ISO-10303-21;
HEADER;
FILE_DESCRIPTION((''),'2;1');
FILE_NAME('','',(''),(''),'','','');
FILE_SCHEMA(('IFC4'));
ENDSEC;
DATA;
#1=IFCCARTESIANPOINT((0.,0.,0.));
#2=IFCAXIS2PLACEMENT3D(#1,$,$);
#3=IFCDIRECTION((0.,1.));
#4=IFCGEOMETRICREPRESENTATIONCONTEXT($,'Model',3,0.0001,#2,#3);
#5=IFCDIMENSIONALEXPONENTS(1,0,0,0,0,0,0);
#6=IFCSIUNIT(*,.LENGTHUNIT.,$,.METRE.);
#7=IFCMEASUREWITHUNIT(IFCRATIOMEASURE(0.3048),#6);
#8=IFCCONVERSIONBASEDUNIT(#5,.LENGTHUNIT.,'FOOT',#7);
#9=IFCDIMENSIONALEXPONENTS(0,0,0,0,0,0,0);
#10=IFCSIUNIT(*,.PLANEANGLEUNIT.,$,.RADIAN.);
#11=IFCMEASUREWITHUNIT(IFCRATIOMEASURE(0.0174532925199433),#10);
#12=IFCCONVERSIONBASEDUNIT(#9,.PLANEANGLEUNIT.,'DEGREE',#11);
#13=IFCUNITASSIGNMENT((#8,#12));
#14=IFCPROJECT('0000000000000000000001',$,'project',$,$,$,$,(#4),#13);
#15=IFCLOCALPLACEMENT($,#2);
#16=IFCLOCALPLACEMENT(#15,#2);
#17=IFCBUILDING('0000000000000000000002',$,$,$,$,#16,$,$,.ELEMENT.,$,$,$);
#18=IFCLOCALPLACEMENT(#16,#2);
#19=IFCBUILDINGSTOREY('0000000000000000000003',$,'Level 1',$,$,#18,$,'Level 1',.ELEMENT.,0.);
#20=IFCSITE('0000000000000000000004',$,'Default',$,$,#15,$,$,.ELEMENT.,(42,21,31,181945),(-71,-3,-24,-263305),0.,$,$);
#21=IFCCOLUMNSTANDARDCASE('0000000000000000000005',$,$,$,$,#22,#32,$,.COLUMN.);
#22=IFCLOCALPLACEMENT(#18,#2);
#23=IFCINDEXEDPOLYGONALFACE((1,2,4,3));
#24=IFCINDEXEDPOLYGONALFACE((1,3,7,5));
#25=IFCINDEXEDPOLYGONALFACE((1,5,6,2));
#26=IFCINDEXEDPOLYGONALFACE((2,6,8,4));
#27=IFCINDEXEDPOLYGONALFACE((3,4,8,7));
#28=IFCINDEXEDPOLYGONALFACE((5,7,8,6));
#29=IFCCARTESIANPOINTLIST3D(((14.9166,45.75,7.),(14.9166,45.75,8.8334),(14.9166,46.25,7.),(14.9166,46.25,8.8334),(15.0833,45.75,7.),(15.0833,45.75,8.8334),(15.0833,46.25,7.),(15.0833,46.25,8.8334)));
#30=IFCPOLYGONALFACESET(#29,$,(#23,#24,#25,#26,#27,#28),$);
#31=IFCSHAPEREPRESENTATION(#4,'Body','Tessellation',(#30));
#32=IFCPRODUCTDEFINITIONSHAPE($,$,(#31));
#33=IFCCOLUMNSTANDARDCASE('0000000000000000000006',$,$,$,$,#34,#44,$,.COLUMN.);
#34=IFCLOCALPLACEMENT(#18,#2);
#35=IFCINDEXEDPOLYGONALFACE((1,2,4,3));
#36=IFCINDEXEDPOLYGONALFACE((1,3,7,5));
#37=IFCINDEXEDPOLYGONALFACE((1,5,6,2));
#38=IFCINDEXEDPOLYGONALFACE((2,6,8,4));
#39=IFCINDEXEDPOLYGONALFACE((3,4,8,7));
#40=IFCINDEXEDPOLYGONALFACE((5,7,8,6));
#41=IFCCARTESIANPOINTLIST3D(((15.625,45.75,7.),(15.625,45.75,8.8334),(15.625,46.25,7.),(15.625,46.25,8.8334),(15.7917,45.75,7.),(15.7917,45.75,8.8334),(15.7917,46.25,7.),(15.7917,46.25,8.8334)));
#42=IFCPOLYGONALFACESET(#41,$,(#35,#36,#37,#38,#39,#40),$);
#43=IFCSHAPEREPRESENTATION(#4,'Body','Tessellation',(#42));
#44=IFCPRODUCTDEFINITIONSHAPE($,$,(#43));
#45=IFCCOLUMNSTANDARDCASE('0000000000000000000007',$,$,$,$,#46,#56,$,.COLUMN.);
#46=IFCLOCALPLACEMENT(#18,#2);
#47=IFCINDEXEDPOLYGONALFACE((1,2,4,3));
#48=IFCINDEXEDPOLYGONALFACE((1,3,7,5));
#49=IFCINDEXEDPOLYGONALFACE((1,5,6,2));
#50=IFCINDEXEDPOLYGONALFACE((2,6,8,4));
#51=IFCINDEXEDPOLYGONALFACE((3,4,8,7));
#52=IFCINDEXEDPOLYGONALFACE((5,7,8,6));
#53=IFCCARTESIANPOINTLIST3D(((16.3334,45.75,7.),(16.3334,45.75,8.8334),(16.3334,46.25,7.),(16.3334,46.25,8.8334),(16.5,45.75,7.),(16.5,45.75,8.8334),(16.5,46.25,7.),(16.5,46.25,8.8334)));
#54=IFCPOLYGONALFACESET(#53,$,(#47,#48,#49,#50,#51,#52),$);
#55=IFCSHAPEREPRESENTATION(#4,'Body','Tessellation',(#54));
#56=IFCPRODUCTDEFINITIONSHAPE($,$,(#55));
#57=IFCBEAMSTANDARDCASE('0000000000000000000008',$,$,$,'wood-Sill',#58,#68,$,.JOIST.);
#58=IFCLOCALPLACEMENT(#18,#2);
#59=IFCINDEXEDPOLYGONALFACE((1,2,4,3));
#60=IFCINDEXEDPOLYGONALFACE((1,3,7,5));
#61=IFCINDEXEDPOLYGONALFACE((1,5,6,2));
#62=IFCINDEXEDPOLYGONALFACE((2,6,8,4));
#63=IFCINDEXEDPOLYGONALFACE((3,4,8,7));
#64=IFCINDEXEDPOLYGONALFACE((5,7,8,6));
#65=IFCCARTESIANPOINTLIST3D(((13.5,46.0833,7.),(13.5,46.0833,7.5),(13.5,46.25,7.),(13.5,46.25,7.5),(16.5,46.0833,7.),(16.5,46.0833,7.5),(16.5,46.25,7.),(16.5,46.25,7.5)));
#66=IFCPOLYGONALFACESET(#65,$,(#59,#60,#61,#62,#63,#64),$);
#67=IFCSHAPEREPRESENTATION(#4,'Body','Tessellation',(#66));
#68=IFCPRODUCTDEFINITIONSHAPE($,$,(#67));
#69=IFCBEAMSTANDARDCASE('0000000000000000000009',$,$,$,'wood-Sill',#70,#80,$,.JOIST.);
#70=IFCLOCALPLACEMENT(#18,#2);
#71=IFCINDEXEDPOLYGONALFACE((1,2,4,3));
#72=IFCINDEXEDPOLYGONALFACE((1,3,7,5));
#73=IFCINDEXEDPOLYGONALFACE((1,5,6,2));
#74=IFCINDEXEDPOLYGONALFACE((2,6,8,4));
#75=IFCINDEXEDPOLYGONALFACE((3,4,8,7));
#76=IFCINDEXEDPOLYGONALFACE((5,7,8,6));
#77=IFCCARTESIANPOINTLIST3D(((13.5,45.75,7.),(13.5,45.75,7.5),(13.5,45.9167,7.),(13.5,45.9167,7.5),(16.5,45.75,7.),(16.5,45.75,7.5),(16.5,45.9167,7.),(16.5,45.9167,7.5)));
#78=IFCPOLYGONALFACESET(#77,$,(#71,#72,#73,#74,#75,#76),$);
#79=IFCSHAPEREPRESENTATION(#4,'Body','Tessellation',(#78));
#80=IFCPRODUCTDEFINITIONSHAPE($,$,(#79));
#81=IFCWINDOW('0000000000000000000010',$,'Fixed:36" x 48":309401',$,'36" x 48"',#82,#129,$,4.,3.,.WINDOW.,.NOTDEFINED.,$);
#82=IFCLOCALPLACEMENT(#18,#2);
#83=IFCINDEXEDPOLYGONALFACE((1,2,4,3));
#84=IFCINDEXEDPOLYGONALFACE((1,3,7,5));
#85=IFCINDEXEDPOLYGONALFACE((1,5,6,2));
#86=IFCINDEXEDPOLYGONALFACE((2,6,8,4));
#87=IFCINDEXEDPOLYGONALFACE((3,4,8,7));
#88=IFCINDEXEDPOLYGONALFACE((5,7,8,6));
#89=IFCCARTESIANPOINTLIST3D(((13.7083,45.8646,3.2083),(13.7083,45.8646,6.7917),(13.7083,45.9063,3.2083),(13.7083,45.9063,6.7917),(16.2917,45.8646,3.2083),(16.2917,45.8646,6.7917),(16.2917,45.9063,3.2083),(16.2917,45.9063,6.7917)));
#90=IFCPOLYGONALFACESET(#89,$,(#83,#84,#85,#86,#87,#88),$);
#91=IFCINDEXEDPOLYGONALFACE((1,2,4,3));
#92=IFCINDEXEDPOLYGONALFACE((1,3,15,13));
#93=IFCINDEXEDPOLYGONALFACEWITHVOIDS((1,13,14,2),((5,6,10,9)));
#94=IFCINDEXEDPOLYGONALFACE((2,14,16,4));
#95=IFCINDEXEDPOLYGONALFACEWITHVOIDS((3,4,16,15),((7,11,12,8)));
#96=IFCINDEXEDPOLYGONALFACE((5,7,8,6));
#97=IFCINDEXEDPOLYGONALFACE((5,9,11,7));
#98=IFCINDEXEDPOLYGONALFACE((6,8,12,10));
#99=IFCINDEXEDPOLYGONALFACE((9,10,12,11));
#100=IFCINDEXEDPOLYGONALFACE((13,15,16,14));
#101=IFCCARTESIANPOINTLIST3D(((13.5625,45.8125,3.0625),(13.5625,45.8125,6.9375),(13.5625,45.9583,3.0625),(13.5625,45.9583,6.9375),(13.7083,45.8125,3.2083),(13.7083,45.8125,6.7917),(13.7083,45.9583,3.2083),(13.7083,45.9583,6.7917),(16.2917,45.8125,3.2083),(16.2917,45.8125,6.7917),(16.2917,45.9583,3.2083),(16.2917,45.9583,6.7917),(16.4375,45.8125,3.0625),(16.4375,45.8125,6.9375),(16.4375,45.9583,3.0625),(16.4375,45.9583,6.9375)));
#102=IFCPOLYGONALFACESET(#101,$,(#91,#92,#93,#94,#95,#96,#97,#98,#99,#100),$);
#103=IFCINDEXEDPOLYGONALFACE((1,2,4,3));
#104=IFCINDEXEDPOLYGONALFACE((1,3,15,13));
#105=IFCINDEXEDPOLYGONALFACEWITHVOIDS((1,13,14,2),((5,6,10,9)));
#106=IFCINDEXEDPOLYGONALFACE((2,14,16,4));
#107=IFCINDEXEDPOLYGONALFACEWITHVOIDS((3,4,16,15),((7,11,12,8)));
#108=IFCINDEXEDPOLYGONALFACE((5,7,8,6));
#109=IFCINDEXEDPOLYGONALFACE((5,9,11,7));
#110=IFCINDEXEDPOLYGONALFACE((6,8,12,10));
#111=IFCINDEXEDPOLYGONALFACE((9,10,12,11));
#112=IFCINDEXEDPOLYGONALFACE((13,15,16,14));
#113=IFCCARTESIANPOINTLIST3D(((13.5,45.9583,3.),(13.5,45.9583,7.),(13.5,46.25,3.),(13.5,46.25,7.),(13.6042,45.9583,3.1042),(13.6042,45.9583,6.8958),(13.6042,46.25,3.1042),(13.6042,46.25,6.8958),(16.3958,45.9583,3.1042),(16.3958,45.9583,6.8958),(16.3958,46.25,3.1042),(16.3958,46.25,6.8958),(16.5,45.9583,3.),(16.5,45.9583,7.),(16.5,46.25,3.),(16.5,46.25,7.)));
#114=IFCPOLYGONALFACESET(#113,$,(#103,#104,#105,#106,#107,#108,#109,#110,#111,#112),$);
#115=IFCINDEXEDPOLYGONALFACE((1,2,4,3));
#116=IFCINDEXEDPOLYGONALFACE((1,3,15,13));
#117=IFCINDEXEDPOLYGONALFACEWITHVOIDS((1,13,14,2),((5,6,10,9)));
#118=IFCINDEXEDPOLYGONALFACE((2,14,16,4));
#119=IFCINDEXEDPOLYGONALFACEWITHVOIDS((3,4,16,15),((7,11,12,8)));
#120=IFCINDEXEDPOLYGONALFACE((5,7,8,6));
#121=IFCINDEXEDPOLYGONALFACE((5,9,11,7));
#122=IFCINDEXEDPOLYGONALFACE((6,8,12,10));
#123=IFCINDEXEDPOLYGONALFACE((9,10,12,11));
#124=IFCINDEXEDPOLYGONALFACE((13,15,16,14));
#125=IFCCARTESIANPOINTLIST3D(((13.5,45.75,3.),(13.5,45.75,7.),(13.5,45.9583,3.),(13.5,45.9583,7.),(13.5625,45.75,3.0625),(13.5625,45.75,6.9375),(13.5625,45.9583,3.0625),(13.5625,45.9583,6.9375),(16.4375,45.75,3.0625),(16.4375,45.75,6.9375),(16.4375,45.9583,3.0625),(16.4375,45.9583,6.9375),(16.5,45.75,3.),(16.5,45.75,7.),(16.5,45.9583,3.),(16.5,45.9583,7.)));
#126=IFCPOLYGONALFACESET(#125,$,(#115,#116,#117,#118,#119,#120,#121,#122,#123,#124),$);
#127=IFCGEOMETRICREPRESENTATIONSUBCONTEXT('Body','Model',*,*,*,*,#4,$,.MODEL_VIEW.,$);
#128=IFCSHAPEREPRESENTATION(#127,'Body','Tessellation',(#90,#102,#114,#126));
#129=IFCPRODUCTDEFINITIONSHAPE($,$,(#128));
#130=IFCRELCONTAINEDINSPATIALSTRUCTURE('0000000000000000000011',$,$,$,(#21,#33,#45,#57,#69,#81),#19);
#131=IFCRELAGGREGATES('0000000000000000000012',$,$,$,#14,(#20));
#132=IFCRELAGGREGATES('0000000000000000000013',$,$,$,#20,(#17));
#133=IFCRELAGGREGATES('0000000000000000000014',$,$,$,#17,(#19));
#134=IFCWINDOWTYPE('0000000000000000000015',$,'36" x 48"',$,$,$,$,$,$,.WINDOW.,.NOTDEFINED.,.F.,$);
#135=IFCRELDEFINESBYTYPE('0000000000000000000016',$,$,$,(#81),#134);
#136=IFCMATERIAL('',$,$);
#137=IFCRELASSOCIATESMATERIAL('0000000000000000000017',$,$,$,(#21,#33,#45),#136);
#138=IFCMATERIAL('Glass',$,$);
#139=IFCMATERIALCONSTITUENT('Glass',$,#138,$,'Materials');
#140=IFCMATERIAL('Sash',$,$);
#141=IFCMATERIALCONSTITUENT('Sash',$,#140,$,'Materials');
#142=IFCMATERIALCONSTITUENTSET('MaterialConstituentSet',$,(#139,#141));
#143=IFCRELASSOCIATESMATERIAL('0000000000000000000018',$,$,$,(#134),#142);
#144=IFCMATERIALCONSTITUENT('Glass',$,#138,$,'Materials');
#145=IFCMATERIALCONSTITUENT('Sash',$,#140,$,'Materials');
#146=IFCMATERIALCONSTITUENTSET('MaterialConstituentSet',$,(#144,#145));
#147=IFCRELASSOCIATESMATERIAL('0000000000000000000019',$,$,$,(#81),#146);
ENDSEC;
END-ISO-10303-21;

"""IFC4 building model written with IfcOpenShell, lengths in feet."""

from ifc_helpers import new_model, entity, si_unit, converted_unit, direction, frame, frame_2d, origin, origin_with_axes, place, context, subcontext, project, spatial, polyline, rectangle, outline, extrude, source, transform, mapped, material, constituent, constituent_set, type_object, type_shapes, element, save


model = new_model("IFC4")

# Units and contexts
model_context = context("Model", 3, precision=0.0001, world=origin(), true_north=direction((0.0, 1.0)))
body_context = subcontext(model_context, "Body", "Model", "MODEL_VIEW")
ifc_project = project(units=[converted_unit("LENGTHUNIT", "FOOT", entity("IfcRatioMeasure", 0.3048), si_unit("LENGTHUNIT", "METRE"), dimensions=[1, 0, 0, 0, 0, 0, 0]), converted_unit("PLANEANGLEUNIT", "DEGREE", entity("IfcRatioMeasure", 0.0174532925199433), si_unit("PLANEANGLEUNIT", "RADIAN"), dimensions=[0, 0, 0, 0, 0, 0, 0])], contexts=[model_context])

# Site, building, storey
site_placement = place(None, origin())
site = spatial("IfcSite", under=ifc_project, at=site_placement, Name="Default", CompositionType="ELEMENT", RefLatitude=(42, 21, 31, 181945), RefLongitude=(-71, -3, -24, -263305), RefElevation=0.0)
building_placement = place(site_placement, origin())
building = spatial("IfcBuilding", under=site, at=building_placement, CompositionType="ELEMENT")
storey_placement = place(building_placement, origin())
storey = spatial("IfcBuildingStorey", under=building, at=storey_placement, Name="Level 1", LongName="Level 1", CompositionType="ELEMENT", Elevation=0.0)

# Columns
placement_1 = place(storey_placement, frame((-0.25, 46.0, 0.0)))
ifc_material_1 = material(Name="")
for number, where, z_axis, x_axis in (
    (1, (15.25, 0.0, 7.0), (0.0, 0.0, 1.0), (1.0, 0.0, 0.0)),
    (2, (15.9584, 0.0, 7.0), (0.0, 0.0, 1.0), (1.0, 0.0, 0.0)),
    (3, (16.6667, 0.0, 7.0), (0.0, 0.0, 1.0), (1.0, 0.0, 0.0)),
):
    element("IfcColumnStandardCase", number, at=place(placement_1, frame(where, z_axis=z_axis, x_axis=x_axis)), inside=storey, material=ifc_material_1, PredefinedType="COLUMN", context=model_context, shape_type="SweptSolid", body=[
        extrude(rectangle(XDim=0.1667, YDim=0.5), origin(), (0.0, 0.0, 1.0), 1.8334),
    ])

# Beams
for number, where, z_axis, x_axis in (
    (4, (13.75, 0.1667, 7.25), (1.0, 0.0, 0.0), (0.0, 0.0, 1.0)),
    (5, (13.75, -0.1667, 7.25), (1.0, 0.0, 0.0), (0.0, 0.0, 1.0)),
):
    element("IfcBeamStandardCase", number, at=place(placement_1, frame(where, z_axis=z_axis, x_axis=x_axis)), inside=storey, ObjectType="wood-Sill", PredefinedType="JOIST", context=model_context, shape_type="SweptSolid", body=[
        extrude(rectangle(XDim=0.5, YDim=0.1667), origin_with_axes(), (0.0, 0.0, 1.0), 3.0),
    ])

# Window
ifc_material_2 = material(Name="Glass")
ifc_constituent_1 = constituent(ifc_material_2, Name="Glass", Category="Materials")
ifc_material_3 = material(Name="Sash")
ifc_constituent_2 = constituent(ifc_material_3, Name="Sash", Category="Materials")
ifc_constituent_set_1 = constituent_set(constituents=[ifc_constituent_1, ifc_constituent_2], Name="MaterialConstituentSet")
ifc_constituent_3 = constituent(ifc_material_2, Name="Glass", Category="Materials")
ifc_constituent_4 = constituent(ifc_material_3, Name="Sash", Category="Materials")
ifc_constituent_set_2 = constituent_set(constituents=[ifc_constituent_3, ifc_constituent_4], Name="MaterialConstituentSet")
window_type = type_object("IfcWindowType", Name="36\" x 48\"", ParameterTakesPrecedence=False, PartitioningType="NOTDEFINED", PredefinedType="WINDOW", material=ifc_constituent_set_2)
shared_shape = source(origin(), body_context, "Body", "SweptSolid", [
    extrude(rectangle(XDim=0.0417, YDim=2.5833, at=frame_2d((0.0, 0.0), x_axis=(1.0, 0.0))), frame((1.5, 0.3646, 0.2083), z_axis=(0.0, 0.0, 1.0), x_axis=(0.0, 1.0, 0.0)), (0.0, 0.0, 1.0), 3.5833),
    extrude(outline(polyline([(-1.4375, -1.9375), (1.4375, -1.9375), (1.4375, 1.9375), (-1.4375, 1.9375), (-1.4375, -1.9375)]), holes=[polyline([(-1.2917, -1.7917), (-1.2917, 1.7917), (1.2917, 1.7917), (1.2917, -1.7917), (-1.2917, -1.7917)])]), frame((1.5, 0.2917, 2.0), z_axis=(0.0, 1.0, 0.0), x_axis=(1.0, 0.0, 0.0)), (0.0, 0.0, 1.0), 0.1458),
    extrude(outline(polyline([(-1.5, -2.0), (1.5, -2.0), (1.5, 2.0), (-1.5, 2.0), (-1.5, -2.0)]), holes=[polyline([(-1.3958, -1.8958), (-1.3958, 1.8958), (1.3958, 1.8958), (1.3958, -1.8958), (-1.3958, -1.8958)])]), frame((1.5, 0.0, 2.0), z_axis=(0.0, 1.0, 0.0), x_axis=(1.0, 0.0, 0.0)), (0.0, 0.0, 1.0), 0.2917),
    extrude(outline(polyline([(-2.0, -1.5), (2.0, -1.5), (2.0, 1.5), (-2.0, 1.5), (-2.0, -1.5)]), holes=[polyline([(-1.9375, -1.4375), (-1.9375, 1.4375), (1.9375, 1.4375), (1.9375, -1.4375), (-1.9375, -1.4375)])]), frame((1.5, 0.2917, 2.0), z_axis=(0.0, 1.0, 0.0), x_axis=(0.0, 0.0, -1.0)), (0.0, 0.0, 1.0), 0.2083),
])
type_shapes(window_type, [shared_shape])
placement_2 = place(placement_1, frame((16.75, 0.25, 3.0)))
window_placement = place(placement_2, frame((0.0, 0.0, 0.0), z_axis=(0.0, 0.0, 1.0), x_axis=(-1.0, 0.0, 0.0)))
element("IfcWindow", 6, at=window_placement, inside=storey, type_object=window_type, material=ifc_constituent_set_1, Name="Fixed:36\" x 48\":309401", ObjectType="36\" x 48\"", OverallHeight=4.0, OverallWidth=3.0, PartitioningType="NOTDEFINED", PredefinedType="WINDOW", context=body_context, shape_type="MappedRepresentation", body=[
    mapped(shared_shape, transform((0.0, 0.0, 0.0), scale=1.0)),
])

save(model, "model.ifc")
